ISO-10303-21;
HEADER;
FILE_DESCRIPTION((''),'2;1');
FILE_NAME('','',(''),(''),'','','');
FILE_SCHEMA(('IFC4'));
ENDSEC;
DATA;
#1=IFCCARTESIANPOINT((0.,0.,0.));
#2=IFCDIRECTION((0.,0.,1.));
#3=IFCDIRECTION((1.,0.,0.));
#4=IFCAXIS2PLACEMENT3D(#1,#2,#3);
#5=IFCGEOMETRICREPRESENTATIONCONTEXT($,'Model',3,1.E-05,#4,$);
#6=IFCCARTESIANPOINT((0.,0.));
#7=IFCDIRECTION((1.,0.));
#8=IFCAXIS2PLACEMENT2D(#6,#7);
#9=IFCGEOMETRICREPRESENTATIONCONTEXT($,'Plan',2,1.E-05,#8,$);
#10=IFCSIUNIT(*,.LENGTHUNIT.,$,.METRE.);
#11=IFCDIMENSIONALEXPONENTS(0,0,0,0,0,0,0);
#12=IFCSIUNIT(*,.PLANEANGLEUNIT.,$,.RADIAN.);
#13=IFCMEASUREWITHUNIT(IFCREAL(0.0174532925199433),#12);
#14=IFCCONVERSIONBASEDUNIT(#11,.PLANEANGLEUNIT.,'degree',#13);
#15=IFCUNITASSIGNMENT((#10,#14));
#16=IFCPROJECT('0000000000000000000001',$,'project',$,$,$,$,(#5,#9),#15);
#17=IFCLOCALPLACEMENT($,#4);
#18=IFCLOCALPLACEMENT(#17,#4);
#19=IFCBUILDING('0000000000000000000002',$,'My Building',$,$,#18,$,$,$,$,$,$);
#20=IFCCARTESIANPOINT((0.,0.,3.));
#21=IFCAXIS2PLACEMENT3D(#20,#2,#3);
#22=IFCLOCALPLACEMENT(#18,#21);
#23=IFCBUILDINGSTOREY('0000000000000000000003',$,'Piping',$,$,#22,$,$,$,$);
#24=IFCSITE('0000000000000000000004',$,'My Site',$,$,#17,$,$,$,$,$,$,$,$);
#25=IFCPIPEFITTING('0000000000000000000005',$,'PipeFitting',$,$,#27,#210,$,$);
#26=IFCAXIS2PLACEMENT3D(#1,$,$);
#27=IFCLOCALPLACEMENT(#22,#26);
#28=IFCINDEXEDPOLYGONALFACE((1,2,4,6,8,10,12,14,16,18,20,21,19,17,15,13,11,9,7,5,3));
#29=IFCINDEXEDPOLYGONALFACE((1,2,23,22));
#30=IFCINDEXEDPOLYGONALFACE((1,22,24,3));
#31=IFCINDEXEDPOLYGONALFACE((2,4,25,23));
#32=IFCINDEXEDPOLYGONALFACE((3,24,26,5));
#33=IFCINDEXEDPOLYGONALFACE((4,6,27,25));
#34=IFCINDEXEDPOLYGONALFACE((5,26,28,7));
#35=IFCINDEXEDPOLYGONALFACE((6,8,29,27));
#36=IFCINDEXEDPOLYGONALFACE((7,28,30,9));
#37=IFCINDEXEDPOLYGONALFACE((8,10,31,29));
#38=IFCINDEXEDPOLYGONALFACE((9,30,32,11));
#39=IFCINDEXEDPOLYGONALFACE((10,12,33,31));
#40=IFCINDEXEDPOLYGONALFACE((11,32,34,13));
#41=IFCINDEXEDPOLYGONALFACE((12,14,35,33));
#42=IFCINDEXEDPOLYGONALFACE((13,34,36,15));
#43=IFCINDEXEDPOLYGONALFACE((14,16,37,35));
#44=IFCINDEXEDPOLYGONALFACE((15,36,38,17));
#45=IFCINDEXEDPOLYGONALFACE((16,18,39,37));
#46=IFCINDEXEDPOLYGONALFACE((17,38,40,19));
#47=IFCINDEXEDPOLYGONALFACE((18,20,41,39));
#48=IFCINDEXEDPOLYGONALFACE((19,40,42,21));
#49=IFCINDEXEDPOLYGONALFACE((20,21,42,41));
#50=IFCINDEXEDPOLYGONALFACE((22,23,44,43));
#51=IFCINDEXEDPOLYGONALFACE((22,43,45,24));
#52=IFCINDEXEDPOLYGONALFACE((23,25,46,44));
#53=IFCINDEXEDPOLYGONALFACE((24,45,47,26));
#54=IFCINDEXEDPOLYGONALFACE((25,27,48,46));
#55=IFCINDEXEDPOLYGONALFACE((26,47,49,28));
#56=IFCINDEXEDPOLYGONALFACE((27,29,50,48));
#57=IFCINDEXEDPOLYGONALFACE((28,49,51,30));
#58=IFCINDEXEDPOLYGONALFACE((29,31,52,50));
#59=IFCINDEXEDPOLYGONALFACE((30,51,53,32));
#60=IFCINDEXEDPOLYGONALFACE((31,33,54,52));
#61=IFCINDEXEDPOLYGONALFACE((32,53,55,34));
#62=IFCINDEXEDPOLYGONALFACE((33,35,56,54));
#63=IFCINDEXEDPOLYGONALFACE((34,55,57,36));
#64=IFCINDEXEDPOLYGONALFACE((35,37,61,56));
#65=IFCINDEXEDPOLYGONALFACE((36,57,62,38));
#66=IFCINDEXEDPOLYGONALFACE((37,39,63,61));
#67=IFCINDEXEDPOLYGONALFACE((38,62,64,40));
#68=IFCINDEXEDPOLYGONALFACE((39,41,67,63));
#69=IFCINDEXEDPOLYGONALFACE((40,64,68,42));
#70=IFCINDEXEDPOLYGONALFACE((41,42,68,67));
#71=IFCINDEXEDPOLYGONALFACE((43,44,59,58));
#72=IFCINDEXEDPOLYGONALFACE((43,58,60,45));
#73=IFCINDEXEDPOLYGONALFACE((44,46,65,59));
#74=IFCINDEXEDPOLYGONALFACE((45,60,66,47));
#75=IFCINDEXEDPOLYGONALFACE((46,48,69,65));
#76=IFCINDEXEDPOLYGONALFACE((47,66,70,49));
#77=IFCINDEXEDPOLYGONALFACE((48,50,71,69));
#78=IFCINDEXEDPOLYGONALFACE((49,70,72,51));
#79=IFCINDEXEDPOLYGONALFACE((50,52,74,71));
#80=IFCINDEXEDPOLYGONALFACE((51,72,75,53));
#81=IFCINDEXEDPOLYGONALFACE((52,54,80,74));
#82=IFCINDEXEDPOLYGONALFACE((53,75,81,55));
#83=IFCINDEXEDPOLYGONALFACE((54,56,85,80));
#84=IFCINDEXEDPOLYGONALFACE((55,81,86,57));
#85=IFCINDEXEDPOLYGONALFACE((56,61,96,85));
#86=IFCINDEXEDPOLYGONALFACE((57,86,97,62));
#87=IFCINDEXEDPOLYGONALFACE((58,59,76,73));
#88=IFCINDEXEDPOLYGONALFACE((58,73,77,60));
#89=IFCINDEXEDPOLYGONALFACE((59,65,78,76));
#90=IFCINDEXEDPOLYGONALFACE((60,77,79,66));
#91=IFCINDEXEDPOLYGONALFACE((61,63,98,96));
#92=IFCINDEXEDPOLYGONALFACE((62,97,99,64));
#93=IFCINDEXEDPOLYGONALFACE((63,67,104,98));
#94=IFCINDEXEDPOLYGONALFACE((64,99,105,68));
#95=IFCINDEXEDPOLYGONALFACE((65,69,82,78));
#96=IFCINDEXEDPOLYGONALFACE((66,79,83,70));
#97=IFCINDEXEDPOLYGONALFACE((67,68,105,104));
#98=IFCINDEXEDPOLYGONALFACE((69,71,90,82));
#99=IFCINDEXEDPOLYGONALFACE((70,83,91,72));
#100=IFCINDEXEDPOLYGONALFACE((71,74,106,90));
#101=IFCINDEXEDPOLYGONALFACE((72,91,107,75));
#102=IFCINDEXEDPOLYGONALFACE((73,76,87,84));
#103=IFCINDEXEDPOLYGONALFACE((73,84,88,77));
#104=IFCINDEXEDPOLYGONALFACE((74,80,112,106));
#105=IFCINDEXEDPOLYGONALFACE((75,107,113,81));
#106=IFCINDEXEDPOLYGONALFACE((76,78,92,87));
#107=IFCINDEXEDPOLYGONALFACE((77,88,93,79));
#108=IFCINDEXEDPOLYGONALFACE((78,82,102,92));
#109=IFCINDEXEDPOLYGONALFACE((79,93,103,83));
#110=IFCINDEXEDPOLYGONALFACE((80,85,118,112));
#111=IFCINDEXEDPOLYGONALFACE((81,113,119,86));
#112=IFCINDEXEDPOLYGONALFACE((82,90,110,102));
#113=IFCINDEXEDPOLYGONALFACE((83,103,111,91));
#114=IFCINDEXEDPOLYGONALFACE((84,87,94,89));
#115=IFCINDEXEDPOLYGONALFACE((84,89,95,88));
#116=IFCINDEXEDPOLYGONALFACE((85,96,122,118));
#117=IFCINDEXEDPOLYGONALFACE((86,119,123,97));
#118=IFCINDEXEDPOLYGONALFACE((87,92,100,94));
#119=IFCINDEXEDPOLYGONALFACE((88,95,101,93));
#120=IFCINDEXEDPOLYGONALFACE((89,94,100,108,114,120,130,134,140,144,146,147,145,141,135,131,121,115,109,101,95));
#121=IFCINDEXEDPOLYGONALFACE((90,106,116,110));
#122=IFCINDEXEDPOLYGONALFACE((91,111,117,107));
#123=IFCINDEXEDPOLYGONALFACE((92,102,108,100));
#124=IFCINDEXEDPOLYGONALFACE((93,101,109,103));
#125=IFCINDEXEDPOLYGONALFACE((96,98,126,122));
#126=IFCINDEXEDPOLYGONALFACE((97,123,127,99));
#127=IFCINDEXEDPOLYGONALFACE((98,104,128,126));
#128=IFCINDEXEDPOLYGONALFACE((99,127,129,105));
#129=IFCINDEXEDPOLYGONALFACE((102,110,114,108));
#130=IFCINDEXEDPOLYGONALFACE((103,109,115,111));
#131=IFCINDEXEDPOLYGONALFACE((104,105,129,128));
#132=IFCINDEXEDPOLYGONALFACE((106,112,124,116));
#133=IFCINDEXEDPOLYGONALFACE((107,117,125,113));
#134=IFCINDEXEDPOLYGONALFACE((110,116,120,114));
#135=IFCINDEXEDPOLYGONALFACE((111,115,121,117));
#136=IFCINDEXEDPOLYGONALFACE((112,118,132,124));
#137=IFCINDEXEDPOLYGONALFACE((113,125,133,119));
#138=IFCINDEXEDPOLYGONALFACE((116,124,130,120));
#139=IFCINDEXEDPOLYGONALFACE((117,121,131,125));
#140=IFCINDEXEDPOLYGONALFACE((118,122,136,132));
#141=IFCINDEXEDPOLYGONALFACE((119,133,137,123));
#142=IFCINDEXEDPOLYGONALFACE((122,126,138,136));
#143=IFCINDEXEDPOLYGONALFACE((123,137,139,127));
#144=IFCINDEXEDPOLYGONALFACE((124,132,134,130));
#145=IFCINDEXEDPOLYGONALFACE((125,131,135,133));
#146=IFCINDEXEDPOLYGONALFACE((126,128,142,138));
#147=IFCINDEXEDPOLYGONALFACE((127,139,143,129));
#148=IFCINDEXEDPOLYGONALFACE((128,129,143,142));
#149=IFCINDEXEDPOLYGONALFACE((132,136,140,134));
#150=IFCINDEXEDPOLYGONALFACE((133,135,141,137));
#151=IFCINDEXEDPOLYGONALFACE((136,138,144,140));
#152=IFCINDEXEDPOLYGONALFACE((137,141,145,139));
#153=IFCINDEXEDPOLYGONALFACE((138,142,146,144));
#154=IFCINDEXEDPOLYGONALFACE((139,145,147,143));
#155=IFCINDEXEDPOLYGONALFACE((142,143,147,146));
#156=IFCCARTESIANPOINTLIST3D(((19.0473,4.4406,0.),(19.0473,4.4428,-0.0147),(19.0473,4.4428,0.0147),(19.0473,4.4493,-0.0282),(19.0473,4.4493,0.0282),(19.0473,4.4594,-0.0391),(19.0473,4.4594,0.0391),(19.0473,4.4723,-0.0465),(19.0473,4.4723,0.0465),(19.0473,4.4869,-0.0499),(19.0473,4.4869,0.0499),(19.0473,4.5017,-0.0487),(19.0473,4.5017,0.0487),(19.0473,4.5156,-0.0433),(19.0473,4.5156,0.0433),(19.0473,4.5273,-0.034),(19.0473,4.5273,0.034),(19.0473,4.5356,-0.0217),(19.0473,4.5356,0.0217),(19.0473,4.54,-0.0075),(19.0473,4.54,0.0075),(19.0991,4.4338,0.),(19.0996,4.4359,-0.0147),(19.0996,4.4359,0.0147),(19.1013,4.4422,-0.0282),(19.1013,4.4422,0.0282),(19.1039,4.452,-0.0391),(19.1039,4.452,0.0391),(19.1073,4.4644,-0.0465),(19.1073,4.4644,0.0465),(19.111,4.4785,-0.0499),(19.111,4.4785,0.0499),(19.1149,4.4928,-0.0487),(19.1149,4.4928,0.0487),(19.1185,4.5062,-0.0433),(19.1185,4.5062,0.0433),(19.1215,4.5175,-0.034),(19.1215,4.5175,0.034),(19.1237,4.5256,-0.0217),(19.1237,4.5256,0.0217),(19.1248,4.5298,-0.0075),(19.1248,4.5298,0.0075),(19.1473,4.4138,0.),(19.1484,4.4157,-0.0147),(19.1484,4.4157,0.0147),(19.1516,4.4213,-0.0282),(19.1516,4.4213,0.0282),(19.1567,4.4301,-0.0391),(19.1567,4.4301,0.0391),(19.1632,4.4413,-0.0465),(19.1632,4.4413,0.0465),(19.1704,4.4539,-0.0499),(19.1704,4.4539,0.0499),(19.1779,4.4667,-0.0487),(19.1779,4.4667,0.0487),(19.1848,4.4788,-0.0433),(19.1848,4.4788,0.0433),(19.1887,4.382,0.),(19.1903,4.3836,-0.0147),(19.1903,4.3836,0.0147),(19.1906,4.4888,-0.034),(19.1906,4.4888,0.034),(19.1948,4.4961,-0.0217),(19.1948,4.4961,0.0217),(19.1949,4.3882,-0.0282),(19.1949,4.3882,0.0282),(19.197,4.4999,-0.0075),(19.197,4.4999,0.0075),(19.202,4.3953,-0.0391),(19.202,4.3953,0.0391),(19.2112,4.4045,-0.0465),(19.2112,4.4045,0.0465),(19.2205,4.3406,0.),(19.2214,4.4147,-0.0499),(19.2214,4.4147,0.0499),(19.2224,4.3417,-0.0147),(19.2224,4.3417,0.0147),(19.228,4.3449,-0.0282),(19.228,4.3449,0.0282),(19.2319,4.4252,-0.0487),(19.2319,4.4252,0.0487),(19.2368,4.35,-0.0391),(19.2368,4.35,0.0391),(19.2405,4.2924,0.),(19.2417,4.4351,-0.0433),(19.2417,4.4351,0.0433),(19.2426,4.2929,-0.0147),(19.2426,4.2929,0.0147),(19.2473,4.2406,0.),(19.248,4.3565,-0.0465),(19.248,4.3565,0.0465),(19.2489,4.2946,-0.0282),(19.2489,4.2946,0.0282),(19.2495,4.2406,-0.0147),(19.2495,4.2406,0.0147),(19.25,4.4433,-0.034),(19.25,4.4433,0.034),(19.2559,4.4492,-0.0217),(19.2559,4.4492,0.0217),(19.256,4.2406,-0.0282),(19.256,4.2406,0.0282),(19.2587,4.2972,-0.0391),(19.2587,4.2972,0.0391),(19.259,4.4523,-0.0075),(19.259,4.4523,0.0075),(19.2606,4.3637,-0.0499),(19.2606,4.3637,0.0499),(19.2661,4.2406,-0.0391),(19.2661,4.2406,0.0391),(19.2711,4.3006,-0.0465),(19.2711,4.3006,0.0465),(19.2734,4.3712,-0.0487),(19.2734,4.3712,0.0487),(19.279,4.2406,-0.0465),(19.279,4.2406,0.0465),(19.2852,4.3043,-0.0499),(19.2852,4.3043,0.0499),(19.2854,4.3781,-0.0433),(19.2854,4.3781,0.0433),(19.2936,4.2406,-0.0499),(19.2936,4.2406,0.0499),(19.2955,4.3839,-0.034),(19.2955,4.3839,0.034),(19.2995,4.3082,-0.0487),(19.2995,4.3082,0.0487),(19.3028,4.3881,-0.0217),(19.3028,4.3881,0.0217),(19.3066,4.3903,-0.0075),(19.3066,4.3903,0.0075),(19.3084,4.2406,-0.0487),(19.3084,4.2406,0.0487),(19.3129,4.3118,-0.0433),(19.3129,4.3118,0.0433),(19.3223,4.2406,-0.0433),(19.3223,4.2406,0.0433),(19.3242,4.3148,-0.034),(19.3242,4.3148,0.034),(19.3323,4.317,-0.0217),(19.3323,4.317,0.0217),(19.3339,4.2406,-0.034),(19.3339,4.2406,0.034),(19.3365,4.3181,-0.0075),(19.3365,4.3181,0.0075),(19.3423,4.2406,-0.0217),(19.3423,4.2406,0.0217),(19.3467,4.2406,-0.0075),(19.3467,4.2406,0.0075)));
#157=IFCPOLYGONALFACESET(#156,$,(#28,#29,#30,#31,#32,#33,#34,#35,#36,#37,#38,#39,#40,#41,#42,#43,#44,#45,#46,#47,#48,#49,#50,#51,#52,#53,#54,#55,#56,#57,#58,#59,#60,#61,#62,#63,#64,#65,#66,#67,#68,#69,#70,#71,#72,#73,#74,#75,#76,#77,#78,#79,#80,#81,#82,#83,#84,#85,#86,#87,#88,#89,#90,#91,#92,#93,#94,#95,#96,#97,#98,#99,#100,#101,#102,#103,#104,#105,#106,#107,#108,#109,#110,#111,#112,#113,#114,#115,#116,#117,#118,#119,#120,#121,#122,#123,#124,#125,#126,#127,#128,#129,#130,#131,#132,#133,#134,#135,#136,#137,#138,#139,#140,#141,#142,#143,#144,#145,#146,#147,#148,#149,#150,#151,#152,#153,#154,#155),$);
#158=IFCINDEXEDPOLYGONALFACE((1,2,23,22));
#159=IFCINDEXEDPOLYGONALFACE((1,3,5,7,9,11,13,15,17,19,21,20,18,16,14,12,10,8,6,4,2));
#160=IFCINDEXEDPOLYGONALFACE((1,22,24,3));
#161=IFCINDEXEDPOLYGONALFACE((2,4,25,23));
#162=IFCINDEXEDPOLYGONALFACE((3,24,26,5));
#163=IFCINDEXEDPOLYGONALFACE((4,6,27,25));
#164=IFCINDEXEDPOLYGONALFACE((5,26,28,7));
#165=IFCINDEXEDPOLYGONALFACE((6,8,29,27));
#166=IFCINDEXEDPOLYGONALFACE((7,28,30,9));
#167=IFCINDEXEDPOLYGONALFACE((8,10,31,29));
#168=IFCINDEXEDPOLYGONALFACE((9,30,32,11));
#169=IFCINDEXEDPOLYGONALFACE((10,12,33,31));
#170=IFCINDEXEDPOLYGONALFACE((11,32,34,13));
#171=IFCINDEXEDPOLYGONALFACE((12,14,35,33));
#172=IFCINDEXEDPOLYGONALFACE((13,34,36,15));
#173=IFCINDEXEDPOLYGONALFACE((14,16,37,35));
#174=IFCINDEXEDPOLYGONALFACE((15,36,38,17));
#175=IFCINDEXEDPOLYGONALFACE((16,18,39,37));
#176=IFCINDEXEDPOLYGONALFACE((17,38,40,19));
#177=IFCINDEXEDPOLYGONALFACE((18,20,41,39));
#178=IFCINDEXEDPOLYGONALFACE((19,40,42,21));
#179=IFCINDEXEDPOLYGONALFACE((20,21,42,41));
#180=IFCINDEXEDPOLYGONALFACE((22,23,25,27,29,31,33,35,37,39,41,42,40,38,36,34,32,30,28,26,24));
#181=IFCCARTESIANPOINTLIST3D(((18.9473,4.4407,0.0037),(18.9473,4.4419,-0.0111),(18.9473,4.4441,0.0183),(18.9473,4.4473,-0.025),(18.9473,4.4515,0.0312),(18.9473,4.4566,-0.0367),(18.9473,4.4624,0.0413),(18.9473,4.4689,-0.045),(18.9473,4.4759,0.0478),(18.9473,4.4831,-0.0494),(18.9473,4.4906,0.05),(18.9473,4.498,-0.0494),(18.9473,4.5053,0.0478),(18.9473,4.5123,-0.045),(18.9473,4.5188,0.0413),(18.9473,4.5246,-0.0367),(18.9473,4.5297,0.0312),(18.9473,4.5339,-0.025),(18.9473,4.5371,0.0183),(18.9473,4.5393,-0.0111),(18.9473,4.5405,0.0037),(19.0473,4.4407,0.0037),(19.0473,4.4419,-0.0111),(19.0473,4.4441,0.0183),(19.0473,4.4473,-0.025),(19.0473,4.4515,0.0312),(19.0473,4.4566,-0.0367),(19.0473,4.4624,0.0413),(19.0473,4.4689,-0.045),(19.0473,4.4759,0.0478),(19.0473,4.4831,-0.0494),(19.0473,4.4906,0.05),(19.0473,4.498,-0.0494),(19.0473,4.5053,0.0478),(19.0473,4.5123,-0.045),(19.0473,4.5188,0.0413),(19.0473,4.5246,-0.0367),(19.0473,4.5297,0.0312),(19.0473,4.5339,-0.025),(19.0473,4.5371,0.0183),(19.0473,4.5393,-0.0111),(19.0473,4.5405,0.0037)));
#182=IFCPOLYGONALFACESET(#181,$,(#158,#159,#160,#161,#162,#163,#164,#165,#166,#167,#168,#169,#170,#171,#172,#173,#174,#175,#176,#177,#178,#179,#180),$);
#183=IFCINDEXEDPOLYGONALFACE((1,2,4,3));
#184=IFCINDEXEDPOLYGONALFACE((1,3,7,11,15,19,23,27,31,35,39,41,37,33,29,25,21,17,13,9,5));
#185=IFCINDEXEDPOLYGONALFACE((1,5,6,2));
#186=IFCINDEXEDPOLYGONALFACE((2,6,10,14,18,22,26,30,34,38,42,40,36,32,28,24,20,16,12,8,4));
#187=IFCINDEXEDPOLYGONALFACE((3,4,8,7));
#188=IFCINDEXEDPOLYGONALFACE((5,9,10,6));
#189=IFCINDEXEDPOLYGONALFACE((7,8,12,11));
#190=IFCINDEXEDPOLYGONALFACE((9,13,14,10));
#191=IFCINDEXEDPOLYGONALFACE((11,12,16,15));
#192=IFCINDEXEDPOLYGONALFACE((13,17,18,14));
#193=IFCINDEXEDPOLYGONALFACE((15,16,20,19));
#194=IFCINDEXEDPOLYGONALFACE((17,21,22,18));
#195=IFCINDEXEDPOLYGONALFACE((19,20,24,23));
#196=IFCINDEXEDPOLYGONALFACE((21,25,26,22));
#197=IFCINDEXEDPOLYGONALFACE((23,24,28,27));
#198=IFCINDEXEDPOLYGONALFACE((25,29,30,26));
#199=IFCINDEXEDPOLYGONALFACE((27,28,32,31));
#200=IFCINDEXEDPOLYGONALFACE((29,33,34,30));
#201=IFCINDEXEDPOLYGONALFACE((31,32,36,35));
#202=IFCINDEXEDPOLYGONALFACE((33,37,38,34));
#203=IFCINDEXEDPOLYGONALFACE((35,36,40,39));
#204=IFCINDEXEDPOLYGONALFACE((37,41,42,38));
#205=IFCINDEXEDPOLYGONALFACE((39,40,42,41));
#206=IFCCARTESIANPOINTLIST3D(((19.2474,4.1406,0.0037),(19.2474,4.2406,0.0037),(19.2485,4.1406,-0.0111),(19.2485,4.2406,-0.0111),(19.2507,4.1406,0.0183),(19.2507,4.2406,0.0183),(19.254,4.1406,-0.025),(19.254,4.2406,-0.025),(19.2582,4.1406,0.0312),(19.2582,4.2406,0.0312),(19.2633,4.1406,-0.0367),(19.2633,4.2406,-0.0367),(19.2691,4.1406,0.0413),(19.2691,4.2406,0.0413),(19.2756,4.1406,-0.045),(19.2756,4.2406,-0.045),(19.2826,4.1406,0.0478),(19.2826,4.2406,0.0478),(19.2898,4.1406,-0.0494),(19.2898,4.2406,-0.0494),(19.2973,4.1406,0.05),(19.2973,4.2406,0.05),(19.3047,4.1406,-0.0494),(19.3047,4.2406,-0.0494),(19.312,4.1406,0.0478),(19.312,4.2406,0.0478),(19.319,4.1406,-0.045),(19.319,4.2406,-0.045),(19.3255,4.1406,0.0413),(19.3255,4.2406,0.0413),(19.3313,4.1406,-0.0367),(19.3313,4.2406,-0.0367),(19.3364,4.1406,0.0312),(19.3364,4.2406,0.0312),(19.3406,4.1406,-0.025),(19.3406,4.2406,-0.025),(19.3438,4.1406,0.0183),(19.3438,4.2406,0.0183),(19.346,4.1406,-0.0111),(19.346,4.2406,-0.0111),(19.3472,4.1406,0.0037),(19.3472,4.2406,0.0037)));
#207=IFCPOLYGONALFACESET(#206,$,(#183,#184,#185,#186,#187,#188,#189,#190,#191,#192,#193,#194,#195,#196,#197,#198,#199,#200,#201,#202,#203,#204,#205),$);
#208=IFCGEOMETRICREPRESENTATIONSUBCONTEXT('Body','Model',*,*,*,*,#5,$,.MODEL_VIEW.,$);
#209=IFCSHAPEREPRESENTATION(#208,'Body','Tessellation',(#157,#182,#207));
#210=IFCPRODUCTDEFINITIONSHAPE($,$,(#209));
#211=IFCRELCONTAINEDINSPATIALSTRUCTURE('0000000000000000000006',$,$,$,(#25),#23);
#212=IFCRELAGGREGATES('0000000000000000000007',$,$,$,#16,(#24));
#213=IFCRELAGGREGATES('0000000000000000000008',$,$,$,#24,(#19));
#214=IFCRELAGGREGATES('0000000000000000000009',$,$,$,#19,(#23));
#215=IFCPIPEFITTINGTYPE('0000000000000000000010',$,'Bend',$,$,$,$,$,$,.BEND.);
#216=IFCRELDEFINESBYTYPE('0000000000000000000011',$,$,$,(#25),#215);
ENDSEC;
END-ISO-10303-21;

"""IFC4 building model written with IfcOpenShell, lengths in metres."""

from ifc_helpers import new_model, entity, si_unit, converted_unit, frame, origin_with_axes, origin_2d_with_axis, place, context, subcontext, project, spatial, circle, extrude, source, transform, mapped, type_object, type_shapes, element, save


model = new_model("IFC4")

# Units and contexts
model_context = context("Model", 3, precision=1e-05, world=origin_with_axes())
plan_context = context("Plan", 2, precision=1e-05, world=origin_2d_with_axis())
body_context = subcontext(model_context, "Body", "Model", "MODEL_VIEW")
ifc_project = project(units=[si_unit("LENGTHUNIT", "METRE"), converted_unit("PLANEANGLEUNIT", "degree", entity("IfcReal", 0.0174532925199433), si_unit("PLANEANGLEUNIT", "RADIAN"), dimensions=[0, 0, 0, 0, 0, 0, 0])], contexts=[model_context, plan_context])

# Site, building, storey
site_placement = place(None, origin_with_axes())
site = spatial("IfcSite", under=ifc_project, at=site_placement, Name="My Site")
building_placement = place(site_placement, origin_with_axes())
building = spatial("IfcBuilding", under=site, at=building_placement, Name="My Building")
storey_placement = place(building_placement, frame((0.0, 0.0, 3.0), z_axis=(0.0, 0.0, 1.0), x_axis=(1.0, 0.0, 0.0)))
storey = spatial("IfcBuildingStorey", under=building, at=storey_placement, Name="Piping")

# Pipe fitting
pipe_fitting_type_1 = type_object("IfcPipeFittingType", Name="Bend", PredefinedType="BEND")
shared_shape = source(origin_with_axes(), body_context, "Body", "SolidModel", [
    entity("IfcSweptDiskSolid", entity("IfcIndexedPolyCurve", entity("IfcCartesianPointList3D", [[0.0, 0.0, -0.1], [0.0, -0.0732, -0.2768], [0.0, -0.25, -0.35]]), [entity("IfcArcIndex", [1, 2, 3])]), 0.05),
    extrude(circle(Radius=0.05), origin_with_axes(), (0.0, 0.0, -1.0), 0.1),
    extrude(circle(Radius=0.05), frame((0.0, -0.25, -0.35), z_axis=(0.0, -1.0, 0.0), x_axis=(1.0, 0.0, 0.0)), (0.0, 0.0, 1.0), 0.1),
])
type_shapes(pipe_fitting_type_1, [shared_shape])
for number, where, z_axis, x_axis, name in (
    (1, (18.9473, 4.4906, 0.0), (-1.0, 0.0, 0.0), (0.0, 0.0, 1.0), "PipeFitting"),
):
    element("IfcPipeFitting", number, at=place(storey_placement, frame(where, z_axis=z_axis, x_axis=x_axis)), inside=storey, type_object=pipe_fitting_type_1, Name=name, context=body_context, shape_type="MappedRepresentation", body=[
        mapped(shared_shape, transform((0.0, 0.0, 0.0), x_axis=(1.0, 0.0, 0.0), y_axis=(0.0, 1.0, 0.0), z_axis=(0.0, 0.0, 1.0), scale=1.0)),
    ])

save(model, "model.ifc")
